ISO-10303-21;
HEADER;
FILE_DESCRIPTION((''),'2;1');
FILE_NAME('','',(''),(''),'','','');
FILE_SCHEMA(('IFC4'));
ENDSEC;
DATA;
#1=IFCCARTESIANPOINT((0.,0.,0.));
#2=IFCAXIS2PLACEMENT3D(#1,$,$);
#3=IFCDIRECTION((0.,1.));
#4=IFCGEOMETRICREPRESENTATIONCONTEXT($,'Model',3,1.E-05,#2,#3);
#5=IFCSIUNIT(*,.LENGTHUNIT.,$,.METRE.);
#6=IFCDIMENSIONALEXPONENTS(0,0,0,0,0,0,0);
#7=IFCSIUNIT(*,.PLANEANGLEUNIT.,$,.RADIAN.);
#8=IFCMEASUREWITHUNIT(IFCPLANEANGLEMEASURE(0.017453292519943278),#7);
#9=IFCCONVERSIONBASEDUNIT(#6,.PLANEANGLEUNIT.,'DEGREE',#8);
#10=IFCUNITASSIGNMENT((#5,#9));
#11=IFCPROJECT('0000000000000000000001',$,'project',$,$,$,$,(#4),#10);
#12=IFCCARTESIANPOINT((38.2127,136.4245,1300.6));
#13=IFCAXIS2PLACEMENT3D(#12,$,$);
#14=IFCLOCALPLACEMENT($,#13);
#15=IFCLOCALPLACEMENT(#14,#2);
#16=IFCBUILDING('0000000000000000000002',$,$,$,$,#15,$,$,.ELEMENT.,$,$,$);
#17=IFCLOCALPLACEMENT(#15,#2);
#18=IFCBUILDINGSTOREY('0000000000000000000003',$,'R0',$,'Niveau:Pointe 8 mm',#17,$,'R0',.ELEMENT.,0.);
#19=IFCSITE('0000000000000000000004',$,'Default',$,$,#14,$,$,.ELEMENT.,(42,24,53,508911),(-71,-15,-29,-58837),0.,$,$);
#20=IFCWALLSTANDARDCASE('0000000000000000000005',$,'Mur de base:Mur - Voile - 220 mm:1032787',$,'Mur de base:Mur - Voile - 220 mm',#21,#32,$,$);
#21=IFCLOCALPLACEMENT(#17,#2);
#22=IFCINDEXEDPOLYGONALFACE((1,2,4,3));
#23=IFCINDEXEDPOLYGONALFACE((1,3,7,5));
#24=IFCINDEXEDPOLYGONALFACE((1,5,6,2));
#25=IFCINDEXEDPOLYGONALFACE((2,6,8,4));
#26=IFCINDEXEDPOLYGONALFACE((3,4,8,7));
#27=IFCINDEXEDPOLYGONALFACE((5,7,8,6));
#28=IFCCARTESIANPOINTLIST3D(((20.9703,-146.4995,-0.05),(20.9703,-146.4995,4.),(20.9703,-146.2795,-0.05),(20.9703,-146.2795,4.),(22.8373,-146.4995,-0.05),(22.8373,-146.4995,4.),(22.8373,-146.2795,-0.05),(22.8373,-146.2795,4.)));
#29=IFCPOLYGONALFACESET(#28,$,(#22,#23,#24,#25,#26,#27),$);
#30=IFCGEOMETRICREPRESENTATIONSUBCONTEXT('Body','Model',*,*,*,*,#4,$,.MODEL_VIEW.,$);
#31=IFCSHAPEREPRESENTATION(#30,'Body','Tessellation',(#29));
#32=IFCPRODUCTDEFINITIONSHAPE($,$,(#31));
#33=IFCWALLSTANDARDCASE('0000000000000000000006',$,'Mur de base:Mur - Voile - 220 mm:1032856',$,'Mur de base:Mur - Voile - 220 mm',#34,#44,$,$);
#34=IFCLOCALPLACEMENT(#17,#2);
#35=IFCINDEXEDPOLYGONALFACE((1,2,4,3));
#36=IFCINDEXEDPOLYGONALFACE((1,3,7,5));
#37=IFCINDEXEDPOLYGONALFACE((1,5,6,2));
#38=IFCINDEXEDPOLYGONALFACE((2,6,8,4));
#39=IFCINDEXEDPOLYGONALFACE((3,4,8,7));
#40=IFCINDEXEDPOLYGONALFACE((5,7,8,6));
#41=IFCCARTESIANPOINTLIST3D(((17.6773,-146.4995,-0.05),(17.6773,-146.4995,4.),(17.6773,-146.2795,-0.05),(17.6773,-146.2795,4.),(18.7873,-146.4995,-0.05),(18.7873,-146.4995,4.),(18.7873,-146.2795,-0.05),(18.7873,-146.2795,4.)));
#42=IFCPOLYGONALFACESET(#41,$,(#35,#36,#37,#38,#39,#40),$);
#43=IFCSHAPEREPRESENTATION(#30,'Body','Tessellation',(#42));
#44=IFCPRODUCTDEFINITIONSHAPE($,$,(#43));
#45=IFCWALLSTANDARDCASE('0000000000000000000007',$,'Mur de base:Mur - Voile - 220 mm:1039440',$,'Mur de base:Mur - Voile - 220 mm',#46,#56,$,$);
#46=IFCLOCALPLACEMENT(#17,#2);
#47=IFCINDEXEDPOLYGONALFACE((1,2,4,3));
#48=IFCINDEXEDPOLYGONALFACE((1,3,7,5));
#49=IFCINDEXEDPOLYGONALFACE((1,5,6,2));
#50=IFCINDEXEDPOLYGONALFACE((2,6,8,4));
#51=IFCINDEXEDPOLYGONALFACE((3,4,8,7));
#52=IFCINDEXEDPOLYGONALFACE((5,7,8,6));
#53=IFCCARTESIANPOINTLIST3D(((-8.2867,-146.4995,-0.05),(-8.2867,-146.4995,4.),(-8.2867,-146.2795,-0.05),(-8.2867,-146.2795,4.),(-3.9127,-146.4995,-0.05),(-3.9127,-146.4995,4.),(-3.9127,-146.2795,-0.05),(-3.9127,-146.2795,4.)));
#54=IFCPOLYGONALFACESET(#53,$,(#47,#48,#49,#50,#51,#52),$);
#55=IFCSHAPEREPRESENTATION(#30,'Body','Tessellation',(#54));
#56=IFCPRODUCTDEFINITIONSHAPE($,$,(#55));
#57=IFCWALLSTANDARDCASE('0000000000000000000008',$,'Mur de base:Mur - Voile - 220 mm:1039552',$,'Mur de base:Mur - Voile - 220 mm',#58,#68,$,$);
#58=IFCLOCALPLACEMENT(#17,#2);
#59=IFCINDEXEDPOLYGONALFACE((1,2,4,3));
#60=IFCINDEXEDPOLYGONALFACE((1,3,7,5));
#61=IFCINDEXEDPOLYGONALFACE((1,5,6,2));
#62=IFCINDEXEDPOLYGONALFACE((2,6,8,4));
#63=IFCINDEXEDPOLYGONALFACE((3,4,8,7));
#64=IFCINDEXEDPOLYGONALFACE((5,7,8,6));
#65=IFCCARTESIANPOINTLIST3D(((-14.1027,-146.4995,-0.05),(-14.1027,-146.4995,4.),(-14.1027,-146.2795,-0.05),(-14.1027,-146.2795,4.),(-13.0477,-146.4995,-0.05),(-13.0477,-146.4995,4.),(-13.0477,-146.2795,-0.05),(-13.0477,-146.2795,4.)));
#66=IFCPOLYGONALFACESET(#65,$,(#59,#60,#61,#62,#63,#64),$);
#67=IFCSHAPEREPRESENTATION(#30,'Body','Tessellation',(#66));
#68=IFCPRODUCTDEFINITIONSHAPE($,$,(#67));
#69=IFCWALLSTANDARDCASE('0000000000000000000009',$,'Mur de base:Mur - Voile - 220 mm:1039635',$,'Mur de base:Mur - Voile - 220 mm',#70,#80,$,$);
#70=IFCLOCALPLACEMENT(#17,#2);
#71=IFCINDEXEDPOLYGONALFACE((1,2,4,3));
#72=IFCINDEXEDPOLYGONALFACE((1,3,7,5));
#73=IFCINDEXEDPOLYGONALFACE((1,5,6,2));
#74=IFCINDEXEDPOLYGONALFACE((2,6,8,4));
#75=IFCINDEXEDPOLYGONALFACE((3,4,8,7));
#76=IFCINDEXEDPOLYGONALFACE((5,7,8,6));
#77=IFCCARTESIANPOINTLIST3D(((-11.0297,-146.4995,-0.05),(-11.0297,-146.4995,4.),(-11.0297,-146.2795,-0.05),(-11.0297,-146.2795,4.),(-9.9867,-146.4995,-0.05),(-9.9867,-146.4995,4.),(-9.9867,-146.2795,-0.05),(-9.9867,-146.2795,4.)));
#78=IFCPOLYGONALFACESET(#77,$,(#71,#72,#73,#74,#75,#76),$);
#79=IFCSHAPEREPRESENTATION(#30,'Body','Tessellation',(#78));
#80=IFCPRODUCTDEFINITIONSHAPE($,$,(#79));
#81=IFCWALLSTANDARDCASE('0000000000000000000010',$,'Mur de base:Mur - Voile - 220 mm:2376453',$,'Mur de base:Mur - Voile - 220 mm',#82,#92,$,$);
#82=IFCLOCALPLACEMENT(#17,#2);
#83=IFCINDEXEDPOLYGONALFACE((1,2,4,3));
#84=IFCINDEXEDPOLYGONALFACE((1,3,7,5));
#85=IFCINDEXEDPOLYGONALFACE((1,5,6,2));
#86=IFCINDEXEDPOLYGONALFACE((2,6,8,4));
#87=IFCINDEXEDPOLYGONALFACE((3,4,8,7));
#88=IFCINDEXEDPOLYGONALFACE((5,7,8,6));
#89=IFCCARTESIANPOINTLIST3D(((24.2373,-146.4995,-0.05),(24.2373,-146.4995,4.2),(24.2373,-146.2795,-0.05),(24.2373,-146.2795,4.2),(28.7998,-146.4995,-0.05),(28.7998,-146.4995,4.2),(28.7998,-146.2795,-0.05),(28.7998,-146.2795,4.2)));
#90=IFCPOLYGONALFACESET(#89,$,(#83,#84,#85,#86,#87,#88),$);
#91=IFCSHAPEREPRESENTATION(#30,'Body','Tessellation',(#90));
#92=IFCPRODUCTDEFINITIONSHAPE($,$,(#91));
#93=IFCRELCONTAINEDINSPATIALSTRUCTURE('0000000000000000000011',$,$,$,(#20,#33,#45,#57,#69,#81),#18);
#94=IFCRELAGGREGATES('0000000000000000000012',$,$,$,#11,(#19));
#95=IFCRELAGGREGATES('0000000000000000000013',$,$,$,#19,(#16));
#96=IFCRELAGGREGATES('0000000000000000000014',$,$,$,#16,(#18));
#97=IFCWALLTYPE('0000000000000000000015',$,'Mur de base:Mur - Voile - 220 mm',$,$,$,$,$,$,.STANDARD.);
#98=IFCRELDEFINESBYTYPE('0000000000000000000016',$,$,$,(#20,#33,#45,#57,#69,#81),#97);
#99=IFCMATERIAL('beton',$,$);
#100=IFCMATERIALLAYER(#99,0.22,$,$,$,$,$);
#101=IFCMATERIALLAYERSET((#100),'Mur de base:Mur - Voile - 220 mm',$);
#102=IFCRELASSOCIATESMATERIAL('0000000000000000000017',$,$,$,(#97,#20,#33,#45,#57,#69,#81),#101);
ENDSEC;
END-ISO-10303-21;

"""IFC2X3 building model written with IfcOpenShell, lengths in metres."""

from ifc_helpers import new_model, entity, si_unit, converted_unit, direction, frame, frame_2d, origin, place, context, subcontext, project, spatial, polyline, rectangle, extrude, clip, bounded_halfspace, material, layer, layer_set, layer_usage, type_object, element, save


model = new_model("IFC2X3")

# Units and contexts
model_context = context("Model", 3, precision=1e-05, world=origin(), true_north=direction((0.0, 1.0)))
body_context = subcontext(model_context, "Body", "Model", "MODEL_VIEW")
ifc_project = project(units=[si_unit("LENGTHUNIT", "METRE"), converted_unit("PLANEANGLEUNIT", "DEGREE", entity("IfcPlaneAngleMeasure", 0.017453292519943278), si_unit("PLANEANGLEUNIT", "RADIAN"), dimensions=[0, 0, 0, 0, 0, 0, 0])], contexts=[model_context])

# Site, building, storey
site_placement = place(None, frame((38.2127, 136.4245, 1300.6)))
site = spatial("IfcSite", under=ifc_project, at=site_placement, Name="Default", CompositionType="ELEMENT", RefLatitude=(42, 24, 53, 508911), RefLongitude=(-71, -15, -29, -58837), RefElevation=0.0)
building_placement = place(site_placement, origin())
building = spatial("IfcBuilding", under=site, at=building_placement, CompositionType="ELEMENT")
storey_placement = place(building_placement, origin())
storey = spatial("IfcBuildingStorey", under=building, at=storey_placement, Name="R0", ObjectType="Niveau:Pointe 8 mm", LongName="R0", CompositionType="ELEMENT", Elevation=0.0)

# Walls
ifc_material_1 = material(Name="beton")
ifc_layer = layer(ifc_material_1, 0.22)
ifc_layer_set = layer_set([ifc_layer], Name="Mur de base:Mur - Voile - 220 mm")
wall_type = type_object("IfcWallType", Name="Mur de base:Mur - Voile - 220 mm", PredefinedType="STANDARD", material=ifc_layer_set)
ifc_layer_usage_1 = layer_usage(ifc_layer_set, "AXIS2", "NEGATIVE", 0.11)
wall_1_placement = place(storey_placement, frame((22.8373, -146.3895, -0.05), z_axis=(0.0, 0.0, 1.0), x_axis=(-1.0, 0.0, 0.0)))
element("IfcWallStandardCase", 1, at=wall_1_placement, inside=storey, type_object=wall_type, material=ifc_layer_usage_1, Name="Mur de base:Mur - Voile - 220 mm:1032787", ObjectType="Mur de base:Mur - Voile - 220 mm", context=body_context, shape_type="Clipping", body=[
    clip(extrude(rectangle(XDim=1.867, YDim=0.22, at=frame_2d((0.9335, 0.0), x_axis=(-1.0, 0.0))), origin(), (0.0, 0.0, 1.0), 4.05), bounded_halfspace(frame((0.0, -0.11, 4.05), z_axis=(0.0, 0.0, -1.0), x_axis=(0.0, -1.0, 0.0)), True, frame((0.0, -0.11, 4.05)), polyline([(0.0, 0.0), (1.867, 0.0), (1.867, 0.22), (0.0, 0.22), (0.0, 0.0)]))),
])
ifc_layer_usage_2 = layer_usage(ifc_layer_set, "AXIS2", "NEGATIVE", 0.11)
wall_2_placement = place(storey_placement, frame((18.7873, -146.3895, -0.05), z_axis=(0.0, 0.0, 1.0), x_axis=(-1.0, 0.0, 0.0)))
element("IfcWallStandardCase", 2, at=wall_2_placement, inside=storey, type_object=wall_type, material=ifc_layer_usage_2, Name="Mur de base:Mur - Voile - 220 mm:1032856", ObjectType="Mur de base:Mur - Voile - 220 mm", context=body_context, shape_type="Clipping", body=[
    clip(extrude(rectangle(XDim=1.11, YDim=0.22, at=frame_2d((0.555, 0.0), x_axis=(-1.0, 0.0))), origin(), (0.0, 0.0, 1.0), 4.05), bounded_halfspace(frame((0.0, -0.11, 4.05), z_axis=(0.0, 0.0, -1.0), x_axis=(0.0, -1.0, 0.0)), True, frame((0.0, -0.11, 4.05)), polyline([(0.0, 0.0), (0.89, 0.0), (1.11, 0.0), (1.11, 0.22), (0.0, 0.22), (0.0, 0.0)]))),
])
ifc_layer_usage_3 = layer_usage(ifc_layer_set, "AXIS2", "NEGATIVE", 0.11)
wall_3_placement = place(storey_placement, frame((-3.9127, -146.3895, -0.05), z_axis=(0.0, 0.0, 1.0), x_axis=(-1.0, 0.0, 0.0)))
element("IfcWallStandardCase", 3, at=wall_3_placement, inside=storey, type_object=wall_type, material=ifc_layer_usage_3, Name="Mur de base:Mur - Voile - 220 mm:1039440", ObjectType="Mur de base:Mur - Voile - 220 mm", context=body_context, shape_type="Clipping", body=[
    clip(extrude(rectangle(XDim=4.374, YDim=0.22, at=frame_2d((2.187, 0.0), x_axis=(-1.0, 0.0))), origin(), (0.0, 0.0, 1.0), 4.05), bounded_halfspace(frame((0.0, -0.11, 4.05), z_axis=(0.0, 0.0, -1.0), x_axis=(0.0, -1.0, 0.0)), True, frame((0.0, -0.11, 4.05)), polyline([(0.0, 0.0), (4.374, 0.0), (4.374, 0.22), (0.0, 0.22), (0.0, 0.0)]))),
])
ifc_layer_usage_4 = layer_usage(ifc_layer_set, "AXIS2", "NEGATIVE", 0.11)
wall_4_placement = place(storey_placement, frame((-13.0477, -146.3895, -0.05), z_axis=(0.0, 0.0, 1.0), x_axis=(-1.0, 0.0, 0.0)))
element("IfcWallStandardCase", 4, at=wall_4_placement, inside=storey, type_object=wall_type, material=ifc_layer_usage_4, Name="Mur de base:Mur - Voile - 220 mm:1039552", ObjectType="Mur de base:Mur - Voile - 220 mm", context=body_context, shape_type="Clipping", body=[
    clip(extrude(rectangle(XDim=1.055, YDim=0.22, at=frame_2d((0.5275, 0.0), x_axis=(-1.0, 0.0))), origin(), (0.0, 0.0, 1.0), 4.05), bounded_halfspace(frame((0.0, -0.11, 4.05), z_axis=(0.0, 0.0, -1.0), x_axis=(0.0, -1.0, 0.0)), True, frame((0.0, -0.11, 4.05)), polyline([(0.0, 0.0), (1.055, 0.0), (1.055, 0.22), (0.0, 0.22), (0.0, 0.0)]))),
])
ifc_layer_usage_5 = layer_usage(ifc_layer_set, "AXIS2", "NEGATIVE", 0.11)
wall_5_placement = place(storey_placement, frame((-9.9867, -146.3895, -0.05), z_axis=(0.0, 0.0, 1.0), x_axis=(-1.0, 0.0, 0.0)))
element("IfcWallStandardCase", 5, at=wall_5_placement, inside=storey, type_object=wall_type, material=ifc_layer_usage_5, Name="Mur de base:Mur - Voile - 220 mm:1039635", ObjectType="Mur de base:Mur - Voile - 220 mm", context=body_context, shape_type="Clipping", body=[
    clip(extrude(rectangle(XDim=1.043, YDim=0.22, at=frame_2d((0.5215, 0.0), x_axis=(-1.0, 0.0))), origin(), (0.0, 0.0, 1.0), 4.05), bounded_halfspace(frame((0.0, -0.11, 4.05), z_axis=(0.0, 0.0, -1.0), x_axis=(0.0, -1.0, 0.0)), True, frame((0.0, -0.11, 4.05)), polyline([(0.0, 0.0), (1.043, 0.0), (1.043, 0.22), (0.0, 0.22), (0.0, 0.0)]))),
])
ifc_layer_usage_6 = layer_usage(ifc_layer_set, "AXIS2", "NEGATIVE", 0.11)
wall_6_placement = place(storey_placement, frame((28.7998, -146.3895, -0.05), z_axis=(0.0, 0.0, 1.0), x_axis=(-1.0, 0.0, 0.0)))
element("IfcWallStandardCase", 6, at=wall_6_placement, inside=storey, type_object=wall_type, material=ifc_layer_usage_6, Name="Mur de base:Mur - Voile - 220 mm:2376453", ObjectType="Mur de base:Mur - Voile - 220 mm", context=body_context, shape_type="SweptSolid", body=[
    extrude(rectangle(XDim=4.5625, YDim=0.22, at=frame_2d((2.2812, 0.0), x_axis=(-1.0, 0.0))), origin(), (0.0, 0.0, 1.0), 4.25),
])

save(model, "model.ifc")
